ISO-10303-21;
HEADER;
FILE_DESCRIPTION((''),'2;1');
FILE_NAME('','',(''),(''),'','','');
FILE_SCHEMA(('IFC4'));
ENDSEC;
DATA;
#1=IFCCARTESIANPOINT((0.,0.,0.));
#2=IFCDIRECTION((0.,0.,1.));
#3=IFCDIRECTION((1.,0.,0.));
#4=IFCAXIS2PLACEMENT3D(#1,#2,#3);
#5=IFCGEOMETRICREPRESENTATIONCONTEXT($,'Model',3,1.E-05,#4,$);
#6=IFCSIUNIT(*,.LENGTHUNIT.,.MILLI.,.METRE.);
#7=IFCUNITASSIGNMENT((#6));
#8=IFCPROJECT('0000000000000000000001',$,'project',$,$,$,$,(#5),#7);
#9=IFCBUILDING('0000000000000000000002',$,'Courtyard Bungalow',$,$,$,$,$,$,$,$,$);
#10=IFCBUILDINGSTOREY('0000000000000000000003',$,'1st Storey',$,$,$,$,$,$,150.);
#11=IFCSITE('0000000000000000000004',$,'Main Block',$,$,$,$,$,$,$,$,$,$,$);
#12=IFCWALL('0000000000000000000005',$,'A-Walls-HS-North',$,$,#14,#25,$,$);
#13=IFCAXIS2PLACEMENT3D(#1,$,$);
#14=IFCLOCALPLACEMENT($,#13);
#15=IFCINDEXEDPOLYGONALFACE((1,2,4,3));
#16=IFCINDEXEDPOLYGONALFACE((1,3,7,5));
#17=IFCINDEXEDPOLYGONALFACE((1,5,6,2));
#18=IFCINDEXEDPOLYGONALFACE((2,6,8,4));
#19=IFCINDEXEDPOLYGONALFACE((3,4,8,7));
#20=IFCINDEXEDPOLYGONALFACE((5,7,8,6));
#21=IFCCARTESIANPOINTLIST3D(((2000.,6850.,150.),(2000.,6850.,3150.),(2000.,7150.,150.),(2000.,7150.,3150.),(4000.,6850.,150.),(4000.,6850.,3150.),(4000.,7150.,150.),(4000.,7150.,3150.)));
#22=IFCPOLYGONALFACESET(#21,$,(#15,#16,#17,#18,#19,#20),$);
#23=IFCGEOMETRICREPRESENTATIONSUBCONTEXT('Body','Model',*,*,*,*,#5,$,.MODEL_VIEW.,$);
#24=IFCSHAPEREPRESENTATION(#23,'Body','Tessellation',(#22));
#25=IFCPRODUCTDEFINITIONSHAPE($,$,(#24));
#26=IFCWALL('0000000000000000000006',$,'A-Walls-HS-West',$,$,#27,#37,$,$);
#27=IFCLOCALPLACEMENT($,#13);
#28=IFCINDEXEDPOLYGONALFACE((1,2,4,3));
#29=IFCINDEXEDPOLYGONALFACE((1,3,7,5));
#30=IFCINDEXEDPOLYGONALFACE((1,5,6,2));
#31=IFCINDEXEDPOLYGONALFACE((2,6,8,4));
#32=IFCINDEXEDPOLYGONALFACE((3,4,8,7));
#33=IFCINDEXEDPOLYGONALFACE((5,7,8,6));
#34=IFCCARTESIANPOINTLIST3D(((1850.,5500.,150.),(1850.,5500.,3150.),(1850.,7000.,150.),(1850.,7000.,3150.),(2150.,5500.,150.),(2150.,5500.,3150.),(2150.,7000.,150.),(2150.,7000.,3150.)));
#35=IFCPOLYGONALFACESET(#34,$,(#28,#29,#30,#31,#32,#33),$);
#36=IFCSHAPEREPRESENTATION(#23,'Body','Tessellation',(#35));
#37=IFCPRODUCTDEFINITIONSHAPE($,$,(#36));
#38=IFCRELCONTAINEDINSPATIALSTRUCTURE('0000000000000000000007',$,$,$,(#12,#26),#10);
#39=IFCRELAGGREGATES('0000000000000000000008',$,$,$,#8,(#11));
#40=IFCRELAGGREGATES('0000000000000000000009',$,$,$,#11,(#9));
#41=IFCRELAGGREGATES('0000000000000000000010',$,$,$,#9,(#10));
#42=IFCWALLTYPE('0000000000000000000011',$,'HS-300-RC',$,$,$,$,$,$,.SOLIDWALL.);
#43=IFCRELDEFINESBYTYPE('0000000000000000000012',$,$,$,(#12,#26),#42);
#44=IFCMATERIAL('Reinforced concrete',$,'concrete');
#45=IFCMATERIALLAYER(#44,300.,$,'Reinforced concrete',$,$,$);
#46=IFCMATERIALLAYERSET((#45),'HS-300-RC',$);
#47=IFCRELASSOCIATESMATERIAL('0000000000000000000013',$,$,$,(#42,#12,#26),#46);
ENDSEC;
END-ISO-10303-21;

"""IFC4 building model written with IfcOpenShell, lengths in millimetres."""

from ifc_helpers import new_model, si_unit, frame, origin_with_axes, place, context, subcontext, project, spatial, indexed_curve, outline, extrude, material, layer, layer_set, layer_usage, type_object, element, save


model = new_model("IFC4")

# Units and contexts
model_context = context("Model", 3, precision=1e-05, world=origin_with_axes())
body_context = subcontext(model_context, "Body", "Model", "MODEL_VIEW")
ifc_project = project(units=[si_unit("LENGTHUNIT", "METRE", prefix="MILLI")], contexts=[model_context])

# Site, building, storey
site = spatial("IfcSite", under=ifc_project, Name="Main Block")
building = spatial("IfcBuilding", under=site, Name="Courtyard Bungalow")
storey = spatial("IfcBuildingStorey", under=building, Name="1st Storey", Elevation=150.0)

# Shared definitions
ifc_material_1 = material(Name="Reinforced concrete", Category="concrete")

# Shared definitions
ifc_layer_1 = layer(ifc_material_1, 300.0, Name="Reinforced concrete")
ifc_layer_set_1 = layer_set([ifc_layer_1], Name="HS-300-RC")
wall_type_1 = type_object("IfcWallType", Name="HS-300-RC", PredefinedType="SOLIDWALL", material=ifc_layer_set_1)

# Walls
ifc_layer_usage_1 = layer_usage(ifc_layer_set_1, "AXIS2", "POSITIVE", 0.0)
wall_1_placement = place(None, frame((4000.0, 7150.0, 150.0), z_axis=(0.0, 0.0, 1.0), x_axis=(-1.0, 0.0, 0.0)))
element("IfcWall", 1, at=wall_1_placement, inside=storey, type_object=wall_type_1, material=ifc_layer_usage_1, Name="A-Walls-HS-North", context=body_context, shape_type="SweptSolid", body=[
    extrude(outline(indexed_curve([(0.0, 0.0), (0.0, 300.0), (2000.0, 300.0), (2000.0, 0.0), (0.0, 0.0)], self_intersect=False)), origin_with_axes(), (0.0, 0.0, 1.0), 3000.0),
])
ifc_layer_usage_2 = layer_usage(ifc_layer_set_1, "AXIS2", "POSITIVE", 0.0)
wall_2_placement = place(None, frame((1850.0, 7000.0, 150.0), z_axis=(0.0, 0.0, 1.0), x_axis=(0.0, -1.0, 0.0)))
element("IfcWall", 2, at=wall_2_placement, inside=storey, type_object=wall_type_1, material=ifc_layer_usage_2, Name="A-Walls-HS-West", context=body_context, shape_type="SweptSolid", body=[
    extrude(outline(indexed_curve([(0.0, 0.0), (0.0, 300.0), (1500.0, 300.0), (1500.0, 0.0), (0.0, 0.0)], self_intersect=False)), origin_with_axes(), (0.0, 0.0, 1.0), 3000.0),
])

save(model, "model.ifc")
